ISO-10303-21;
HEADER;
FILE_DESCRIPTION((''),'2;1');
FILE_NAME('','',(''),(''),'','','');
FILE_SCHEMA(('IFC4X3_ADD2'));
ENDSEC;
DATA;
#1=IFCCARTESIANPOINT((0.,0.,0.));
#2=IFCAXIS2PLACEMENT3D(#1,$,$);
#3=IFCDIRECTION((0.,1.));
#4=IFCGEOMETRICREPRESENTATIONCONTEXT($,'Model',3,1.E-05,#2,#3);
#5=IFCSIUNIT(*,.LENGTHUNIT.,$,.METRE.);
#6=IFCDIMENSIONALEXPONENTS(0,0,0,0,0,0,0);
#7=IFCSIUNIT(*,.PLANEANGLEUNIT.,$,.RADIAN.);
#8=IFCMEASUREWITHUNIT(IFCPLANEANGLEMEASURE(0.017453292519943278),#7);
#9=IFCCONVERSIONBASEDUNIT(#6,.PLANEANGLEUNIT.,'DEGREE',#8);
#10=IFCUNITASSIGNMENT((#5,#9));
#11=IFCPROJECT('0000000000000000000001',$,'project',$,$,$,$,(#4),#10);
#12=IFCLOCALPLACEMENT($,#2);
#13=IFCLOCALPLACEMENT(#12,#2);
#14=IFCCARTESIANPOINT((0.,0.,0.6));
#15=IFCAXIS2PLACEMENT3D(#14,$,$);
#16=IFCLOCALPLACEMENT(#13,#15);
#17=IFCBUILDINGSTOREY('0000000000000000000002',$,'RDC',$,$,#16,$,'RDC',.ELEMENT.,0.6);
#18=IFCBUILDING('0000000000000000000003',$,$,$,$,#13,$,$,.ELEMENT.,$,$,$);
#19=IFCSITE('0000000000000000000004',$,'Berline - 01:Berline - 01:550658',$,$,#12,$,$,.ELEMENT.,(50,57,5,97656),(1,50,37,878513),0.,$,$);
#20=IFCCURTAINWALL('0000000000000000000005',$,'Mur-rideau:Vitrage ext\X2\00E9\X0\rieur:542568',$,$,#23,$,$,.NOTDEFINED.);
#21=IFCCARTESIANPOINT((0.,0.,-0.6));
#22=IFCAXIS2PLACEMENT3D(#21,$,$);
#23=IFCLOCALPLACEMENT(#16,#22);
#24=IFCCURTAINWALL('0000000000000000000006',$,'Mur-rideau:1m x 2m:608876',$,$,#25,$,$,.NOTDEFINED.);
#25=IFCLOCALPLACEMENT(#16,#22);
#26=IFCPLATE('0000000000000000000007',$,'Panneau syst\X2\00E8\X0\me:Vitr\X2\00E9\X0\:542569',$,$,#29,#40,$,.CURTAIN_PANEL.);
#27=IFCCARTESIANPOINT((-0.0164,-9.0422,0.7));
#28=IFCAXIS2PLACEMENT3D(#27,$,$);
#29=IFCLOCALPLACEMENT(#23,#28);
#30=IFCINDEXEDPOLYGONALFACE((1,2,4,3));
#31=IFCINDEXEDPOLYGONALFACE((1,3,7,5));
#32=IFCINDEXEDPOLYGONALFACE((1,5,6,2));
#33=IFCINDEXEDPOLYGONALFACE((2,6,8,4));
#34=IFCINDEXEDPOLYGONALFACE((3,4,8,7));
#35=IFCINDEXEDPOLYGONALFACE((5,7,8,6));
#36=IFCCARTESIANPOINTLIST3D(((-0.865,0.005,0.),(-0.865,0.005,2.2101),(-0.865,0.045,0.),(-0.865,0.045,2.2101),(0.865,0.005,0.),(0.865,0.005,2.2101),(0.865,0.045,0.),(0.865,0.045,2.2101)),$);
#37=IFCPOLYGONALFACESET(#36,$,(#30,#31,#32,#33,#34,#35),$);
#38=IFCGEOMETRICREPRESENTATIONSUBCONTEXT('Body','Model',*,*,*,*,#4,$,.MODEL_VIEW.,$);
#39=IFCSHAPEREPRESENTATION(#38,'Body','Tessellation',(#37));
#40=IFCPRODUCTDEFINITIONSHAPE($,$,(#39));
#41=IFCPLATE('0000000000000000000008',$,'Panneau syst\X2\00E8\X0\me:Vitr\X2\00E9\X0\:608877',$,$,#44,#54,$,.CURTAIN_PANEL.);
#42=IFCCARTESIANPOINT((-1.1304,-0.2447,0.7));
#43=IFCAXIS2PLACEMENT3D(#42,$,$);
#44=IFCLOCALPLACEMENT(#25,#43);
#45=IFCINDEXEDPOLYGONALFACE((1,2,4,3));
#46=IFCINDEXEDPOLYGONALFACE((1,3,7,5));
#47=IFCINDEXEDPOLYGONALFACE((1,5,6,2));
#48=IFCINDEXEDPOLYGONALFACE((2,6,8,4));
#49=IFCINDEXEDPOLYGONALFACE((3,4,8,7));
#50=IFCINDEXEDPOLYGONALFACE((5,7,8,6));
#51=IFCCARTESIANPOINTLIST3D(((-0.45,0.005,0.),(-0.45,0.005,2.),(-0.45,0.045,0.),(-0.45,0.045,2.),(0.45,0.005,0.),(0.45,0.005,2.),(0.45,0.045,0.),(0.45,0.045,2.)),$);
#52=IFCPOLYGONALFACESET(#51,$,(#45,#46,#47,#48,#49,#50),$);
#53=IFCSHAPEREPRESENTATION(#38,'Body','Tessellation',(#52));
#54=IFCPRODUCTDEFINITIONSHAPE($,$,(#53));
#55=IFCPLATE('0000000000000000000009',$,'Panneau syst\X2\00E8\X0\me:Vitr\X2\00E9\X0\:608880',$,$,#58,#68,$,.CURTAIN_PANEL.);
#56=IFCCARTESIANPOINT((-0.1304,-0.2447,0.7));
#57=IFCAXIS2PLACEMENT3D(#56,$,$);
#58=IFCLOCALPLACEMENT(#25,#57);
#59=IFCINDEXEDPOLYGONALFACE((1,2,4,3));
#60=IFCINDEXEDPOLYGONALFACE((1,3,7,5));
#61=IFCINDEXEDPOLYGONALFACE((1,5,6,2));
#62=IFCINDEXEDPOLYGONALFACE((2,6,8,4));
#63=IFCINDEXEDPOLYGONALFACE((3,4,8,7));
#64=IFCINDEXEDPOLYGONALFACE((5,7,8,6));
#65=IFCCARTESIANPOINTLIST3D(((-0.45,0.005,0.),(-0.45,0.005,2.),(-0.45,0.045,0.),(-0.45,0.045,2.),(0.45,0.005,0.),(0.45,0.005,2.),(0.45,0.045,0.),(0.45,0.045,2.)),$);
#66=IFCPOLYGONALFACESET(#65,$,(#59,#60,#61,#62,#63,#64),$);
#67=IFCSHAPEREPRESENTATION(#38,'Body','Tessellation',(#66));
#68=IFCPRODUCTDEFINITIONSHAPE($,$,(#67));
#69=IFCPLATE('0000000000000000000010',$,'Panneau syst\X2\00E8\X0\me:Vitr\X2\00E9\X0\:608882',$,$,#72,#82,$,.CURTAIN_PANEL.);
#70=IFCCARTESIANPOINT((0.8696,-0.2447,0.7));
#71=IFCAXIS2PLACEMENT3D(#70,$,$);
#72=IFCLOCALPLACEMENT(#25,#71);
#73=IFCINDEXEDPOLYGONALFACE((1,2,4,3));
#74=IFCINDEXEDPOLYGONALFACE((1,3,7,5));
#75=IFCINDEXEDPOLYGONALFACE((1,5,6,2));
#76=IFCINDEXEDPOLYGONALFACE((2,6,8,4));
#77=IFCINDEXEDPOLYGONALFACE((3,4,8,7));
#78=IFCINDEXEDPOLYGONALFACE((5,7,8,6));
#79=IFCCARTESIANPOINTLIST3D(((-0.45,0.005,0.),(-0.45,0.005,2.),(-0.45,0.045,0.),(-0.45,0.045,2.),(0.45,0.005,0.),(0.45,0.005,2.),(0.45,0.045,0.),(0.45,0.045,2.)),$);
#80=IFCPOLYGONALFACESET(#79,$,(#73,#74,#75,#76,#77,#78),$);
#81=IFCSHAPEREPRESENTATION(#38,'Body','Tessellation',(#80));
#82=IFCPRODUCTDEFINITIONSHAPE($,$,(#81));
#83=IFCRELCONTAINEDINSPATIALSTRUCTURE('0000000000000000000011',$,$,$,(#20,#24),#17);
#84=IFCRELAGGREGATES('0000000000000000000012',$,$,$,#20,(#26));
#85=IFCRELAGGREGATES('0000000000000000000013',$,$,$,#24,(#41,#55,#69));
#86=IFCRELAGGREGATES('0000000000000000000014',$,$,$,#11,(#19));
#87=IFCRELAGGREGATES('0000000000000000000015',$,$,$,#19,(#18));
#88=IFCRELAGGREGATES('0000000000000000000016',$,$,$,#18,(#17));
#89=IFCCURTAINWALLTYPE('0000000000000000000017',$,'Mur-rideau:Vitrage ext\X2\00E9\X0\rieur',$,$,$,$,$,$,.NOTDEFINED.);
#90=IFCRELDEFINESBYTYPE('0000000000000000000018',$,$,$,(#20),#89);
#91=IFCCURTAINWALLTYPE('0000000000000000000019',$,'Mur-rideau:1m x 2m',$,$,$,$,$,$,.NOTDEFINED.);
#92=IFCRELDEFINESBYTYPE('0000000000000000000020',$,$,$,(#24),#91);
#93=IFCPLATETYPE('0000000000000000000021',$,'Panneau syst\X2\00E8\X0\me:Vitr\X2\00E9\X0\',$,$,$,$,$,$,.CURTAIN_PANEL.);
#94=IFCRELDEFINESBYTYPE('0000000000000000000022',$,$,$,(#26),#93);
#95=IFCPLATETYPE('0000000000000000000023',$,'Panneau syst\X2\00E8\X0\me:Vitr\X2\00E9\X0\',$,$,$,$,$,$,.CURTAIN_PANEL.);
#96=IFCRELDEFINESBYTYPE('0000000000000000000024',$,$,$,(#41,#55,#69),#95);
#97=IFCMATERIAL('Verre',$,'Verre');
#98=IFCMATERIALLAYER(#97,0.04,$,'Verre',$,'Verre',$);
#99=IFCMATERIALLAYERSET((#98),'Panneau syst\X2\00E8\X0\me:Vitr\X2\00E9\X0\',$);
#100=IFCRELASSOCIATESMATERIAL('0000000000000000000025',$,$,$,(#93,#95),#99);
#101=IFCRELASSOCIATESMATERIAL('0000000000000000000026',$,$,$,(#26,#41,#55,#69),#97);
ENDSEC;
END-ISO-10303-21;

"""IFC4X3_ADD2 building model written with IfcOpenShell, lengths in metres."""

from ifc_helpers import new_model, entity, si_unit, converted_unit, direction, frame, frame_2d, origin, place, context, subcontext, project, spatial, rectangle, extrude, source, transform, mapped, material, layer, layer_set, type_object, type_shapes, element, aggregate, save


model = new_model("IFC4X3_ADD2")

# Units and contexts
model_context = context("Model", 3, precision=1e-05, world=origin(), true_north=direction((0.0, 1.0)))
body_context = subcontext(model_context, "Body", "Model", "MODEL_VIEW")
ifc_project = project(units=[si_unit("LENGTHUNIT", "METRE"), converted_unit("PLANEANGLEUNIT", "DEGREE", entity("IfcPlaneAngleMeasure", 0.017453292519943278), si_unit("PLANEANGLEUNIT", "RADIAN"), dimensions=[0, 0, 0, 0, 0, 0, 0])], contexts=[model_context])

# Site, building, storey
site_placement = place(None, origin())
site = spatial("IfcSite", under=ifc_project, at=site_placement, Name="Berline - 01:Berline - 01:550658", CompositionType="ELEMENT", RefLatitude=(50, 57, 5, 97656), RefLongitude=(1, 50, 37, 878513), RefElevation=0.0)
building_placement = place(site_placement, origin())
building = spatial("IfcBuilding", under=site, at=building_placement, CompositionType="ELEMENT")
storey_placement = place(building_placement, frame((0.0, 0.0, 0.6)))
storey = spatial("IfcBuildingStorey", under=building, at=storey_placement, Name="RDC", LongName="RDC", CompositionType="ELEMENT", Elevation=0.6)

# Curtain walls
curtain_wall_type_1 = type_object("IfcCurtainWallType", Name="Mur-rideau:Vitrage extérieur", PredefinedType="NOTDEFINED")
curtain_wall_1_placement = place(storey_placement, frame((0.0, 0.0, -0.6)))
curtain_wall_1 = element("IfcCurtainWall", 1, at=curtain_wall_1_placement, inside=storey, type_object=curtain_wall_type_1, Name="Mur-rideau:Vitrage extérieur:542568", PredefinedType="NOTDEFINED")
curtain_wall_type_2 = type_object("IfcCurtainWallType", Name="Mur-rideau:1m x 2m", PredefinedType="NOTDEFINED")
curtain_wall_2_placement = place(storey_placement, frame((0.0, 0.0, -0.6)))
curtain_wall_2 = element("IfcCurtainWall", 2, at=curtain_wall_2_placement, inside=storey, type_object=curtain_wall_type_2, Name="Mur-rideau:1m x 2m:608876", PredefinedType="NOTDEFINED")

# Plates
ifc_material_1 = material(Name="Verre", Category="Verre")
ifc_layer_1 = layer(ifc_material_1, 0.04, Name="Verre", Category="Verre")
ifc_layer_set_1 = layer_set([ifc_layer_1], Name="Panneau système:Vitré")
plate_type_1 = type_object("IfcPlateType", Name="Panneau système:Vitré", PredefinedType="CURTAIN_PANEL", material=ifc_layer_set_1)
shared_shape_1 = source(origin(), body_context, "Body", "SweptSolid", [
    extrude(rectangle(XDim=0.04, YDim=1.73, at=frame_2d((0.0, 0.0), x_axis=(1.0, 0.0))), frame((0.0, 0.025, 0.0), z_axis=(0.0, 0.0, 1.0), x_axis=(0.0, 1.0, 0.0)), (0.0, 0.0, 1.0), 2.2101),
])
type_shapes(plate_type_1, [shared_shape_1])
plate_1_placement = place(curtain_wall_1_placement, frame((-0.0164, -9.0422, 0.7)))
plate_1 = element("IfcPlate", 3, at=plate_1_placement, type_object=plate_type_1, material=ifc_material_1, Name="Panneau système:Vitré:542569", PredefinedType="CURTAIN_PANEL", context=body_context, shape_type="MappedRepresentation", body=[
    mapped(shared_shape_1, transform((0.0, 0.0, 0.0), scale=1.0)),
])
aggregate(curtain_wall_1, [plate_1])
plate_type_2 = type_object("IfcPlateType", Name="Panneau système:Vitré", PredefinedType="CURTAIN_PANEL", material=ifc_layer_set_1)
shared_shape_2 = source(origin(), body_context, "Body", "SweptSolid", [
    extrude(rectangle(XDim=0.04, YDim=0.9, at=frame_2d((0.0, 0.0), x_axis=(1.0, 0.0))), frame((0.0, 0.025, 0.0), z_axis=(0.0, 0.0, 1.0), x_axis=(0.0, 1.0, 0.0)), (0.0, 0.0, 1.0), 2.0),
])
type_shapes(plate_type_2, [shared_shape_2])
plate_2_placement = place(curtain_wall_2_placement, frame((-1.1304, -0.2447, 0.7)))
plate_2 = element("IfcPlate", 4, at=plate_2_placement, type_object=plate_type_2, material=ifc_material_1, Name="Panneau système:Vitré:608877", PredefinedType="CURTAIN_PANEL", context=body_context, shape_type="MappedRepresentation", body=[
    mapped(shared_shape_2, transform((0.0, 0.0, 0.0), scale=1.0)),
])
plate_3_placement = place(curtain_wall_2_placement, frame((-0.1304, -0.2447, 0.7)))
plate_3 = element("IfcPlate", 5, at=plate_3_placement, type_object=plate_type_2, material=ifc_material_1, Name="Panneau système:Vitré:608880", PredefinedType="CURTAIN_PANEL", context=body_context, shape_type="MappedRepresentation", body=[
    mapped(shared_shape_2, transform((0.0, 0.0, 0.0), scale=1.0)),
])
plate_4_placement = place(curtain_wall_2_placement, frame((0.8696, -0.2447, 0.7)))
plate_4 = element("IfcPlate", 6, at=plate_4_placement, type_object=plate_type_2, material=ifc_material_1, Name="Panneau système:Vitré:608882", PredefinedType="CURTAIN_PANEL", context=body_context, shape_type="MappedRepresentation", body=[
    mapped(shared_shape_2, transform((0.0, 0.0, 0.0), scale=1.0)),
])
aggregate(curtain_wall_2, [plate_2, plate_3, plate_4])

save(model, "model.ifc")
